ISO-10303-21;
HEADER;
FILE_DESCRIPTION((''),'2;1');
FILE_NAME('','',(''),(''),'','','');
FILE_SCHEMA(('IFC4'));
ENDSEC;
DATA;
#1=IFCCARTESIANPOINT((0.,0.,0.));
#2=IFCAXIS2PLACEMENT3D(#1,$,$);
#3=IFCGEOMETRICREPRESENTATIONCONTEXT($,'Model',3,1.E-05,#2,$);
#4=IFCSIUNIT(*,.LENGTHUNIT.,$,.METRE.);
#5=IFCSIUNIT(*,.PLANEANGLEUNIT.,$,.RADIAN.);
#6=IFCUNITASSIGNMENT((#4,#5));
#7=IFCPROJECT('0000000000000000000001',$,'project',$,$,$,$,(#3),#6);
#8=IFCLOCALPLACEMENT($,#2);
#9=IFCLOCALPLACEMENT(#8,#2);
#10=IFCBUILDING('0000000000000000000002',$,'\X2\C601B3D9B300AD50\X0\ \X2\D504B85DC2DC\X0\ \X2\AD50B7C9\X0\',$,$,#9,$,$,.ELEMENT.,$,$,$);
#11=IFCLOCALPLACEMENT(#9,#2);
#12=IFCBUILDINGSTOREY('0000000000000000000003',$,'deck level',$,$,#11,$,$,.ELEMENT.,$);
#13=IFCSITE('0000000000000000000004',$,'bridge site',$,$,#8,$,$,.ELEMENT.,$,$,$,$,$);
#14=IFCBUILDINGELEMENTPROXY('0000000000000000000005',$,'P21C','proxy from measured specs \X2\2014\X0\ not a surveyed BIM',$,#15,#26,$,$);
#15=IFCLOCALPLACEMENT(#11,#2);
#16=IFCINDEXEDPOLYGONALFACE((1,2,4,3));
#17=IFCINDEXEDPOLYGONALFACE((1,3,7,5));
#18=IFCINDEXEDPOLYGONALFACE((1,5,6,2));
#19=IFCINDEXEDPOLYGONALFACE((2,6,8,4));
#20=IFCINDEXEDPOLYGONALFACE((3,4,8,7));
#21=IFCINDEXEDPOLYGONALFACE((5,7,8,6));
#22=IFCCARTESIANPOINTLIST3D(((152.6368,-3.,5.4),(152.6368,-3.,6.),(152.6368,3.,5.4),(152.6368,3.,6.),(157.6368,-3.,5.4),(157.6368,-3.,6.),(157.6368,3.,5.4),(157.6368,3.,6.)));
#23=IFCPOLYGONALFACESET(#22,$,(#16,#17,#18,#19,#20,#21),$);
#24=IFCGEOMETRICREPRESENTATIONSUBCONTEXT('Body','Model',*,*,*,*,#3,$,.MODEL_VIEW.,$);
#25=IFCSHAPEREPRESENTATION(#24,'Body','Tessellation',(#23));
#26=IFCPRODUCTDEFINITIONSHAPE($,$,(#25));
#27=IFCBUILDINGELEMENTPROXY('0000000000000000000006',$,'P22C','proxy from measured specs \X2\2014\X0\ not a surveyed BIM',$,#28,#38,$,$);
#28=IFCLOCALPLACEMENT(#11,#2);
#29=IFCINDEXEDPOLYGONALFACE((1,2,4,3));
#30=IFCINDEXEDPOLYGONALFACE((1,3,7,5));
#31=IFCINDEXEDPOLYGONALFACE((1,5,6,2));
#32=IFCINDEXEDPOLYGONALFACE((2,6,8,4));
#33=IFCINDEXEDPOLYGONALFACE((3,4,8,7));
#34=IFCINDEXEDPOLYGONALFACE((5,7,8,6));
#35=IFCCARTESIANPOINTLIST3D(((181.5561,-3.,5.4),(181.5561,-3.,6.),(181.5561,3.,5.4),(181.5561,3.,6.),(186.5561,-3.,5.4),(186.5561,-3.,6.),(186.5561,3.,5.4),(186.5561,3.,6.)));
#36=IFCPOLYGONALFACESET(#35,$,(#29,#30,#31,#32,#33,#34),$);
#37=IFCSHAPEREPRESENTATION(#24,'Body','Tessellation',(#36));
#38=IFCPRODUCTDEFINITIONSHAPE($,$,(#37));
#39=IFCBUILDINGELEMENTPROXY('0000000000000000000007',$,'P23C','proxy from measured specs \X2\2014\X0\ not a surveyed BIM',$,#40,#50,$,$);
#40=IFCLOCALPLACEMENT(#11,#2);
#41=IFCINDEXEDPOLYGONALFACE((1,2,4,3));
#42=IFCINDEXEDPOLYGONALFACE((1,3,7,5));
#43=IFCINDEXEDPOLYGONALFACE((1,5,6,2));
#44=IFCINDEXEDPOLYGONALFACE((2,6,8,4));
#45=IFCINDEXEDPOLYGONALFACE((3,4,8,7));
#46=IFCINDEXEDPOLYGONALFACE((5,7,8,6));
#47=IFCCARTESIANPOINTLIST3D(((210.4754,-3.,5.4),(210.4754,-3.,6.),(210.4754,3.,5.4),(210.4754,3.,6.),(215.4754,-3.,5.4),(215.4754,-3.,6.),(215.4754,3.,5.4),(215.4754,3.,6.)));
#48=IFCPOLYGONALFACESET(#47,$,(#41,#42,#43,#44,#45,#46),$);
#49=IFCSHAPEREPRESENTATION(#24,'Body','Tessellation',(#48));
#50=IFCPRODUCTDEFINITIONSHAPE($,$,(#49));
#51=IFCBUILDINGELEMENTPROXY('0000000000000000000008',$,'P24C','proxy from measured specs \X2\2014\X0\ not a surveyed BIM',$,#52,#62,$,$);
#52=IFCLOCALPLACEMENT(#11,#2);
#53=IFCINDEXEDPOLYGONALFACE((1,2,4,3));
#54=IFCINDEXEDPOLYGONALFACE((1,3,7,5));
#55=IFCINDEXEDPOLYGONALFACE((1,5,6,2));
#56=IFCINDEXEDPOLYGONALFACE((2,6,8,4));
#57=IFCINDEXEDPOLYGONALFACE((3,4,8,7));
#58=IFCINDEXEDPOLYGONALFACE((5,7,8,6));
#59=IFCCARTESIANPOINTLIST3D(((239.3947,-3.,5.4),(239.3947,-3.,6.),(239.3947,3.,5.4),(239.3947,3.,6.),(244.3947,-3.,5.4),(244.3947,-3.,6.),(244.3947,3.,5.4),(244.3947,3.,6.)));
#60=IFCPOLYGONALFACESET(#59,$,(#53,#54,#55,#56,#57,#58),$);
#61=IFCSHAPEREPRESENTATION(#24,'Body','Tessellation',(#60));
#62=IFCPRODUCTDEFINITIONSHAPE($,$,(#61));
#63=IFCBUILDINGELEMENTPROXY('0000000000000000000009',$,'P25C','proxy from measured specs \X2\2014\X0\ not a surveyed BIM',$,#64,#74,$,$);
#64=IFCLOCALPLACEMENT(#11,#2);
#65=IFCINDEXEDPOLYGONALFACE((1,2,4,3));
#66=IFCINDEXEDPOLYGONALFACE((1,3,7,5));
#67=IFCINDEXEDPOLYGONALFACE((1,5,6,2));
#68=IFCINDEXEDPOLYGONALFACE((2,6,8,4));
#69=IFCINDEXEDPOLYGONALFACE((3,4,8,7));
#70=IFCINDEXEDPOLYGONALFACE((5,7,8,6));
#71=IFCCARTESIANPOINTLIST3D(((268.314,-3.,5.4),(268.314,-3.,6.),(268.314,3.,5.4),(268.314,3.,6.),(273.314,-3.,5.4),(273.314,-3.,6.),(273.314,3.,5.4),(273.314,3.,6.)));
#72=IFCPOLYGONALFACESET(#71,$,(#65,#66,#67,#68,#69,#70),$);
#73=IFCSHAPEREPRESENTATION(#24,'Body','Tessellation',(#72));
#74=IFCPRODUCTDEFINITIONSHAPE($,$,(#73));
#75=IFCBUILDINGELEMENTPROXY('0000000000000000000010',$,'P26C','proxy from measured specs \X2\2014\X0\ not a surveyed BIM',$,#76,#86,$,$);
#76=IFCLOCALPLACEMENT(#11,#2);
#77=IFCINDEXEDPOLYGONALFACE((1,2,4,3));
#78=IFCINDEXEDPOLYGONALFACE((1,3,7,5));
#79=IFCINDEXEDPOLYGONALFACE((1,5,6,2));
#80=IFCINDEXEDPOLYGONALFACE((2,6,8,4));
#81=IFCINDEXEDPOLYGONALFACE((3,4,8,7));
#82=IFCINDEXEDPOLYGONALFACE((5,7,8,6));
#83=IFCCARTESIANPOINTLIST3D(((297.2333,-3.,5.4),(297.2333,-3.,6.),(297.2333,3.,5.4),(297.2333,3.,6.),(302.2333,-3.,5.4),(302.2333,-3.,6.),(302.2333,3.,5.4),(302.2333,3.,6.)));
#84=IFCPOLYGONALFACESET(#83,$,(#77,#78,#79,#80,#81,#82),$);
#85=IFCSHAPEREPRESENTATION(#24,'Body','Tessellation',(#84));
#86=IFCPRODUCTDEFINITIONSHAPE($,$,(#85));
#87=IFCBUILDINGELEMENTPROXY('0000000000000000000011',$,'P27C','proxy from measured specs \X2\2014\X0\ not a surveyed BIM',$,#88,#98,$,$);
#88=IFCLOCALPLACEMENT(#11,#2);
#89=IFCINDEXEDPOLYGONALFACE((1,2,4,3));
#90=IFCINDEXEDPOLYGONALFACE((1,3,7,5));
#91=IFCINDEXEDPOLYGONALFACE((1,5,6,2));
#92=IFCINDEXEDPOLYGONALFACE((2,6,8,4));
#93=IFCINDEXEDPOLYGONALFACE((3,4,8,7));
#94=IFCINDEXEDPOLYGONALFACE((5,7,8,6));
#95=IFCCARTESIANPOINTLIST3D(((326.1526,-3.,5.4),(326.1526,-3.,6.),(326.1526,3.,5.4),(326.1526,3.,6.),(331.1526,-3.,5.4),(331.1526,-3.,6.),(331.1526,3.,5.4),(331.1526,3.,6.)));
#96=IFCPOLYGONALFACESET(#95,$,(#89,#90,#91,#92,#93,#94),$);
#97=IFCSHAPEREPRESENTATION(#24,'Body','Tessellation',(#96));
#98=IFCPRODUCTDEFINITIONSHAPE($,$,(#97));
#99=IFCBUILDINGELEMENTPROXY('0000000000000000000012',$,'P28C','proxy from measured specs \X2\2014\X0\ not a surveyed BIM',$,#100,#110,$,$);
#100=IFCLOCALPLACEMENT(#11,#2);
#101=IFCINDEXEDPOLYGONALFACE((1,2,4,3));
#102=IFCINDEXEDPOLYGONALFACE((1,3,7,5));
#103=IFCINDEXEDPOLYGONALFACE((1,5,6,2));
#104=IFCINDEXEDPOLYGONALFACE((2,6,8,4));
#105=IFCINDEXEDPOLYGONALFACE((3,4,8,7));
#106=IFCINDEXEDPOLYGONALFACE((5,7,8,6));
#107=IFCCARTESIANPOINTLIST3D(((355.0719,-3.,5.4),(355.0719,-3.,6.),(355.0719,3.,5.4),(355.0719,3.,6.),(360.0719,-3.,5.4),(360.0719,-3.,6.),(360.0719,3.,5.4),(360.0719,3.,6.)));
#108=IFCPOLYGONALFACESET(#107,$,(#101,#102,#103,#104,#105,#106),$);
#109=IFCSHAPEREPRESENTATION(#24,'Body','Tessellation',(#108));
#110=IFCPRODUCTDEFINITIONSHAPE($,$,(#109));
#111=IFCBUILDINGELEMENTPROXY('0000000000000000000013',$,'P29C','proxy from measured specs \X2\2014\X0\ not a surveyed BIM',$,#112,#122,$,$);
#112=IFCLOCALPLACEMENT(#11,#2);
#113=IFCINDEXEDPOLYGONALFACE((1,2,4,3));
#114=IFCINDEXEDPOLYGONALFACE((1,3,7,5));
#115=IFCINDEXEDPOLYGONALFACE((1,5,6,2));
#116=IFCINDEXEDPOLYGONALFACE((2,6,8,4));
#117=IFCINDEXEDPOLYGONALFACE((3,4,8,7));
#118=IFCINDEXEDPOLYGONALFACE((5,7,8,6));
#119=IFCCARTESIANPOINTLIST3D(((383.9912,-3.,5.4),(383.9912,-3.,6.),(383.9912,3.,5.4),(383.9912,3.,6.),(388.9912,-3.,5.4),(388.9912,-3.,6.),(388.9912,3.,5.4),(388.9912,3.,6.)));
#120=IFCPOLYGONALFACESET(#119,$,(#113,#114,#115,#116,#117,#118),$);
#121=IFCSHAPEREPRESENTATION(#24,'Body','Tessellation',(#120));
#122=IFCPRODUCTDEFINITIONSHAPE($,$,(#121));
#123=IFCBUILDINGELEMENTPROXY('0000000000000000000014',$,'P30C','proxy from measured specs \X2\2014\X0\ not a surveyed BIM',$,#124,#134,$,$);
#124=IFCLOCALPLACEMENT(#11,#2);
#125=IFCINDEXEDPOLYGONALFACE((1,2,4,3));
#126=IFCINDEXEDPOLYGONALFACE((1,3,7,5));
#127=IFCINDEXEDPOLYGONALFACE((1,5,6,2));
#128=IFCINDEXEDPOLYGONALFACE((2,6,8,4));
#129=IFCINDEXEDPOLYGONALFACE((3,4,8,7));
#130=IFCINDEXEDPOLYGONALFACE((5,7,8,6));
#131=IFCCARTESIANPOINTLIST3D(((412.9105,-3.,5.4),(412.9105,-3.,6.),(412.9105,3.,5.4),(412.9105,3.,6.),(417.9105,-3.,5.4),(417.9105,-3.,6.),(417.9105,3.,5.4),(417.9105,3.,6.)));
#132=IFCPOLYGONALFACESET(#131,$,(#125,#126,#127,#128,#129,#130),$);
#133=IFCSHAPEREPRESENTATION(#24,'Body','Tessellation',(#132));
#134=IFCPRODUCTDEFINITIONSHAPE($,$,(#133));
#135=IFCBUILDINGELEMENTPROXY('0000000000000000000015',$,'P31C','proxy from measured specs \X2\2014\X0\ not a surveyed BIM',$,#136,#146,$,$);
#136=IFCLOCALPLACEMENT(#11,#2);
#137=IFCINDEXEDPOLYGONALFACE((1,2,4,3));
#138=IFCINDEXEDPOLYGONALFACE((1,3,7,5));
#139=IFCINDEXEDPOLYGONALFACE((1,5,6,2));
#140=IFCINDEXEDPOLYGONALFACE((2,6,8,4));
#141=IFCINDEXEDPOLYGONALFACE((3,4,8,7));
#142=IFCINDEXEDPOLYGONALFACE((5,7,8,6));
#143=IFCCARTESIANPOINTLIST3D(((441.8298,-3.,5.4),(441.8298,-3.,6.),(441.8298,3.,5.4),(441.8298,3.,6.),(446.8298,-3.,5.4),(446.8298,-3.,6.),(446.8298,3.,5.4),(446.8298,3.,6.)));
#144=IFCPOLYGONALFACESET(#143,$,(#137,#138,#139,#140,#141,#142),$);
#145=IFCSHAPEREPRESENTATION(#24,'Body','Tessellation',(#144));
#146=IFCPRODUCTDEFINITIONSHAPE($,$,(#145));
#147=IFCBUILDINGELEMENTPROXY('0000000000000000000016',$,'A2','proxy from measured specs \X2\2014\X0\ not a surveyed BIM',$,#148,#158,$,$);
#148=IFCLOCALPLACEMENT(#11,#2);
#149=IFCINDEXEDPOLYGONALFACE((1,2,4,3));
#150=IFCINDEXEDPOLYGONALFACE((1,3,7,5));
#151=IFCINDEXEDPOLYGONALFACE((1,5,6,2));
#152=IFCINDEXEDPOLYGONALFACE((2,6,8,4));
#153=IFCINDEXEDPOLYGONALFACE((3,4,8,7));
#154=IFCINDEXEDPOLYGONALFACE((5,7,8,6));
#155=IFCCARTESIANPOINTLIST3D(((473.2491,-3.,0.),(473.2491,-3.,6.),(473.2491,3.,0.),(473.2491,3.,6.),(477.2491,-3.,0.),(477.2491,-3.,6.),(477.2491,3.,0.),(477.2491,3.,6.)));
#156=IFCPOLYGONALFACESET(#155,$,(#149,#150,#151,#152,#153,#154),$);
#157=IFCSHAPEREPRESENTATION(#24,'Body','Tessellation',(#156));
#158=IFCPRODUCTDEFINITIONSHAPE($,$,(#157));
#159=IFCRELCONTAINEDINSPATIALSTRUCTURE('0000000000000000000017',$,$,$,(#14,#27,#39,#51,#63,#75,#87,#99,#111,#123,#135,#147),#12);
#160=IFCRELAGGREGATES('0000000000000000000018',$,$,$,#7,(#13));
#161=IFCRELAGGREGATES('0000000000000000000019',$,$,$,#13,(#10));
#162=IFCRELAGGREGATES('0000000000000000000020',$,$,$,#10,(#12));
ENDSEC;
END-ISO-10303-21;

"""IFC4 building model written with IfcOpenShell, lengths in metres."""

from ifc_helpers import new_model, si_unit, frame, origin, origin_2d, place, context, subcontext, project, spatial, rectangle, extrude, element, save


model = new_model("IFC4")

# Units and contexts
model_context = context("Model", 3, precision=1e-05, world=origin())
body_context = subcontext(model_context, "Body", "Model", "MODEL_VIEW")
ifc_project = project(units=[si_unit("LENGTHUNIT", "METRE"), si_unit("PLANEANGLEUNIT", "RADIAN")], contexts=[model_context])

# Site, building, storey
site_placement = place(None, origin())
site = spatial("IfcSite", under=ifc_project, at=site_placement, Name="bridge site", CompositionType="ELEMENT")
building_placement = place(site_placement, origin())
building = spatial("IfcBuilding", under=site, at=building_placement, Name="영동대교 프록시 교량", CompositionType="ELEMENT")
storey_placement = place(building_placement, origin())
storey = spatial("IfcBuildingStorey", under=building, at=storey_placement, Name="deck level", CompositionType="ELEMENT")

# Building element proxies
for number, where, name in (
    (1, (155.1368, 0.0, 5.4), "P21C"),
    (2, (184.0561, 0.0, 5.4), "P22C"),
    (3, (212.9754, 0.0, 5.4), "P23C"),
    (4, (241.8947, 0.0, 5.4), "P24C"),
    (5, (270.814, 0.0, 5.4), "P25C"),
    (6, (299.7333, 0.0, 5.4), "P26C"),
    (7, (328.6526, 0.0, 5.4), "P27C"),
    (8, (357.5719, 0.0, 5.4), "P28C"),
    (9, (386.4912, 0.0, 5.4), "P29C"),
    (10, (415.4105, 0.0, 5.4), "P30C"),
    (11, (444.3298, 0.0, 5.4), "P31C"),
):
    element("IfcBuildingElementProxy", number, at=place(storey_placement, frame(where)), inside=storey, Name=name, Description="proxy from measured specs — not a surveyed BIM", context=body_context, shape_type="SweptSolid", body=[
        extrude(rectangle(XDim=5.0, YDim=6.0, at=origin_2d()), origin(), (0.0, 0.0, 1.0), 0.6),
    ])
proxy_placement = place(storey_placement, frame((475.2491, 0.0, 0.0)))
element("IfcBuildingElementProxy", 12, at=proxy_placement, inside=storey, Name="A2", Description="proxy from measured specs — not a surveyed BIM", context=body_context, shape_type="SweptSolid", body=[
    extrude(rectangle(XDim=4.0, YDim=6.0, at=origin_2d()), origin(), (0.0, 0.0, 1.0), 6.0),
])

save(model, "model.ifc")
